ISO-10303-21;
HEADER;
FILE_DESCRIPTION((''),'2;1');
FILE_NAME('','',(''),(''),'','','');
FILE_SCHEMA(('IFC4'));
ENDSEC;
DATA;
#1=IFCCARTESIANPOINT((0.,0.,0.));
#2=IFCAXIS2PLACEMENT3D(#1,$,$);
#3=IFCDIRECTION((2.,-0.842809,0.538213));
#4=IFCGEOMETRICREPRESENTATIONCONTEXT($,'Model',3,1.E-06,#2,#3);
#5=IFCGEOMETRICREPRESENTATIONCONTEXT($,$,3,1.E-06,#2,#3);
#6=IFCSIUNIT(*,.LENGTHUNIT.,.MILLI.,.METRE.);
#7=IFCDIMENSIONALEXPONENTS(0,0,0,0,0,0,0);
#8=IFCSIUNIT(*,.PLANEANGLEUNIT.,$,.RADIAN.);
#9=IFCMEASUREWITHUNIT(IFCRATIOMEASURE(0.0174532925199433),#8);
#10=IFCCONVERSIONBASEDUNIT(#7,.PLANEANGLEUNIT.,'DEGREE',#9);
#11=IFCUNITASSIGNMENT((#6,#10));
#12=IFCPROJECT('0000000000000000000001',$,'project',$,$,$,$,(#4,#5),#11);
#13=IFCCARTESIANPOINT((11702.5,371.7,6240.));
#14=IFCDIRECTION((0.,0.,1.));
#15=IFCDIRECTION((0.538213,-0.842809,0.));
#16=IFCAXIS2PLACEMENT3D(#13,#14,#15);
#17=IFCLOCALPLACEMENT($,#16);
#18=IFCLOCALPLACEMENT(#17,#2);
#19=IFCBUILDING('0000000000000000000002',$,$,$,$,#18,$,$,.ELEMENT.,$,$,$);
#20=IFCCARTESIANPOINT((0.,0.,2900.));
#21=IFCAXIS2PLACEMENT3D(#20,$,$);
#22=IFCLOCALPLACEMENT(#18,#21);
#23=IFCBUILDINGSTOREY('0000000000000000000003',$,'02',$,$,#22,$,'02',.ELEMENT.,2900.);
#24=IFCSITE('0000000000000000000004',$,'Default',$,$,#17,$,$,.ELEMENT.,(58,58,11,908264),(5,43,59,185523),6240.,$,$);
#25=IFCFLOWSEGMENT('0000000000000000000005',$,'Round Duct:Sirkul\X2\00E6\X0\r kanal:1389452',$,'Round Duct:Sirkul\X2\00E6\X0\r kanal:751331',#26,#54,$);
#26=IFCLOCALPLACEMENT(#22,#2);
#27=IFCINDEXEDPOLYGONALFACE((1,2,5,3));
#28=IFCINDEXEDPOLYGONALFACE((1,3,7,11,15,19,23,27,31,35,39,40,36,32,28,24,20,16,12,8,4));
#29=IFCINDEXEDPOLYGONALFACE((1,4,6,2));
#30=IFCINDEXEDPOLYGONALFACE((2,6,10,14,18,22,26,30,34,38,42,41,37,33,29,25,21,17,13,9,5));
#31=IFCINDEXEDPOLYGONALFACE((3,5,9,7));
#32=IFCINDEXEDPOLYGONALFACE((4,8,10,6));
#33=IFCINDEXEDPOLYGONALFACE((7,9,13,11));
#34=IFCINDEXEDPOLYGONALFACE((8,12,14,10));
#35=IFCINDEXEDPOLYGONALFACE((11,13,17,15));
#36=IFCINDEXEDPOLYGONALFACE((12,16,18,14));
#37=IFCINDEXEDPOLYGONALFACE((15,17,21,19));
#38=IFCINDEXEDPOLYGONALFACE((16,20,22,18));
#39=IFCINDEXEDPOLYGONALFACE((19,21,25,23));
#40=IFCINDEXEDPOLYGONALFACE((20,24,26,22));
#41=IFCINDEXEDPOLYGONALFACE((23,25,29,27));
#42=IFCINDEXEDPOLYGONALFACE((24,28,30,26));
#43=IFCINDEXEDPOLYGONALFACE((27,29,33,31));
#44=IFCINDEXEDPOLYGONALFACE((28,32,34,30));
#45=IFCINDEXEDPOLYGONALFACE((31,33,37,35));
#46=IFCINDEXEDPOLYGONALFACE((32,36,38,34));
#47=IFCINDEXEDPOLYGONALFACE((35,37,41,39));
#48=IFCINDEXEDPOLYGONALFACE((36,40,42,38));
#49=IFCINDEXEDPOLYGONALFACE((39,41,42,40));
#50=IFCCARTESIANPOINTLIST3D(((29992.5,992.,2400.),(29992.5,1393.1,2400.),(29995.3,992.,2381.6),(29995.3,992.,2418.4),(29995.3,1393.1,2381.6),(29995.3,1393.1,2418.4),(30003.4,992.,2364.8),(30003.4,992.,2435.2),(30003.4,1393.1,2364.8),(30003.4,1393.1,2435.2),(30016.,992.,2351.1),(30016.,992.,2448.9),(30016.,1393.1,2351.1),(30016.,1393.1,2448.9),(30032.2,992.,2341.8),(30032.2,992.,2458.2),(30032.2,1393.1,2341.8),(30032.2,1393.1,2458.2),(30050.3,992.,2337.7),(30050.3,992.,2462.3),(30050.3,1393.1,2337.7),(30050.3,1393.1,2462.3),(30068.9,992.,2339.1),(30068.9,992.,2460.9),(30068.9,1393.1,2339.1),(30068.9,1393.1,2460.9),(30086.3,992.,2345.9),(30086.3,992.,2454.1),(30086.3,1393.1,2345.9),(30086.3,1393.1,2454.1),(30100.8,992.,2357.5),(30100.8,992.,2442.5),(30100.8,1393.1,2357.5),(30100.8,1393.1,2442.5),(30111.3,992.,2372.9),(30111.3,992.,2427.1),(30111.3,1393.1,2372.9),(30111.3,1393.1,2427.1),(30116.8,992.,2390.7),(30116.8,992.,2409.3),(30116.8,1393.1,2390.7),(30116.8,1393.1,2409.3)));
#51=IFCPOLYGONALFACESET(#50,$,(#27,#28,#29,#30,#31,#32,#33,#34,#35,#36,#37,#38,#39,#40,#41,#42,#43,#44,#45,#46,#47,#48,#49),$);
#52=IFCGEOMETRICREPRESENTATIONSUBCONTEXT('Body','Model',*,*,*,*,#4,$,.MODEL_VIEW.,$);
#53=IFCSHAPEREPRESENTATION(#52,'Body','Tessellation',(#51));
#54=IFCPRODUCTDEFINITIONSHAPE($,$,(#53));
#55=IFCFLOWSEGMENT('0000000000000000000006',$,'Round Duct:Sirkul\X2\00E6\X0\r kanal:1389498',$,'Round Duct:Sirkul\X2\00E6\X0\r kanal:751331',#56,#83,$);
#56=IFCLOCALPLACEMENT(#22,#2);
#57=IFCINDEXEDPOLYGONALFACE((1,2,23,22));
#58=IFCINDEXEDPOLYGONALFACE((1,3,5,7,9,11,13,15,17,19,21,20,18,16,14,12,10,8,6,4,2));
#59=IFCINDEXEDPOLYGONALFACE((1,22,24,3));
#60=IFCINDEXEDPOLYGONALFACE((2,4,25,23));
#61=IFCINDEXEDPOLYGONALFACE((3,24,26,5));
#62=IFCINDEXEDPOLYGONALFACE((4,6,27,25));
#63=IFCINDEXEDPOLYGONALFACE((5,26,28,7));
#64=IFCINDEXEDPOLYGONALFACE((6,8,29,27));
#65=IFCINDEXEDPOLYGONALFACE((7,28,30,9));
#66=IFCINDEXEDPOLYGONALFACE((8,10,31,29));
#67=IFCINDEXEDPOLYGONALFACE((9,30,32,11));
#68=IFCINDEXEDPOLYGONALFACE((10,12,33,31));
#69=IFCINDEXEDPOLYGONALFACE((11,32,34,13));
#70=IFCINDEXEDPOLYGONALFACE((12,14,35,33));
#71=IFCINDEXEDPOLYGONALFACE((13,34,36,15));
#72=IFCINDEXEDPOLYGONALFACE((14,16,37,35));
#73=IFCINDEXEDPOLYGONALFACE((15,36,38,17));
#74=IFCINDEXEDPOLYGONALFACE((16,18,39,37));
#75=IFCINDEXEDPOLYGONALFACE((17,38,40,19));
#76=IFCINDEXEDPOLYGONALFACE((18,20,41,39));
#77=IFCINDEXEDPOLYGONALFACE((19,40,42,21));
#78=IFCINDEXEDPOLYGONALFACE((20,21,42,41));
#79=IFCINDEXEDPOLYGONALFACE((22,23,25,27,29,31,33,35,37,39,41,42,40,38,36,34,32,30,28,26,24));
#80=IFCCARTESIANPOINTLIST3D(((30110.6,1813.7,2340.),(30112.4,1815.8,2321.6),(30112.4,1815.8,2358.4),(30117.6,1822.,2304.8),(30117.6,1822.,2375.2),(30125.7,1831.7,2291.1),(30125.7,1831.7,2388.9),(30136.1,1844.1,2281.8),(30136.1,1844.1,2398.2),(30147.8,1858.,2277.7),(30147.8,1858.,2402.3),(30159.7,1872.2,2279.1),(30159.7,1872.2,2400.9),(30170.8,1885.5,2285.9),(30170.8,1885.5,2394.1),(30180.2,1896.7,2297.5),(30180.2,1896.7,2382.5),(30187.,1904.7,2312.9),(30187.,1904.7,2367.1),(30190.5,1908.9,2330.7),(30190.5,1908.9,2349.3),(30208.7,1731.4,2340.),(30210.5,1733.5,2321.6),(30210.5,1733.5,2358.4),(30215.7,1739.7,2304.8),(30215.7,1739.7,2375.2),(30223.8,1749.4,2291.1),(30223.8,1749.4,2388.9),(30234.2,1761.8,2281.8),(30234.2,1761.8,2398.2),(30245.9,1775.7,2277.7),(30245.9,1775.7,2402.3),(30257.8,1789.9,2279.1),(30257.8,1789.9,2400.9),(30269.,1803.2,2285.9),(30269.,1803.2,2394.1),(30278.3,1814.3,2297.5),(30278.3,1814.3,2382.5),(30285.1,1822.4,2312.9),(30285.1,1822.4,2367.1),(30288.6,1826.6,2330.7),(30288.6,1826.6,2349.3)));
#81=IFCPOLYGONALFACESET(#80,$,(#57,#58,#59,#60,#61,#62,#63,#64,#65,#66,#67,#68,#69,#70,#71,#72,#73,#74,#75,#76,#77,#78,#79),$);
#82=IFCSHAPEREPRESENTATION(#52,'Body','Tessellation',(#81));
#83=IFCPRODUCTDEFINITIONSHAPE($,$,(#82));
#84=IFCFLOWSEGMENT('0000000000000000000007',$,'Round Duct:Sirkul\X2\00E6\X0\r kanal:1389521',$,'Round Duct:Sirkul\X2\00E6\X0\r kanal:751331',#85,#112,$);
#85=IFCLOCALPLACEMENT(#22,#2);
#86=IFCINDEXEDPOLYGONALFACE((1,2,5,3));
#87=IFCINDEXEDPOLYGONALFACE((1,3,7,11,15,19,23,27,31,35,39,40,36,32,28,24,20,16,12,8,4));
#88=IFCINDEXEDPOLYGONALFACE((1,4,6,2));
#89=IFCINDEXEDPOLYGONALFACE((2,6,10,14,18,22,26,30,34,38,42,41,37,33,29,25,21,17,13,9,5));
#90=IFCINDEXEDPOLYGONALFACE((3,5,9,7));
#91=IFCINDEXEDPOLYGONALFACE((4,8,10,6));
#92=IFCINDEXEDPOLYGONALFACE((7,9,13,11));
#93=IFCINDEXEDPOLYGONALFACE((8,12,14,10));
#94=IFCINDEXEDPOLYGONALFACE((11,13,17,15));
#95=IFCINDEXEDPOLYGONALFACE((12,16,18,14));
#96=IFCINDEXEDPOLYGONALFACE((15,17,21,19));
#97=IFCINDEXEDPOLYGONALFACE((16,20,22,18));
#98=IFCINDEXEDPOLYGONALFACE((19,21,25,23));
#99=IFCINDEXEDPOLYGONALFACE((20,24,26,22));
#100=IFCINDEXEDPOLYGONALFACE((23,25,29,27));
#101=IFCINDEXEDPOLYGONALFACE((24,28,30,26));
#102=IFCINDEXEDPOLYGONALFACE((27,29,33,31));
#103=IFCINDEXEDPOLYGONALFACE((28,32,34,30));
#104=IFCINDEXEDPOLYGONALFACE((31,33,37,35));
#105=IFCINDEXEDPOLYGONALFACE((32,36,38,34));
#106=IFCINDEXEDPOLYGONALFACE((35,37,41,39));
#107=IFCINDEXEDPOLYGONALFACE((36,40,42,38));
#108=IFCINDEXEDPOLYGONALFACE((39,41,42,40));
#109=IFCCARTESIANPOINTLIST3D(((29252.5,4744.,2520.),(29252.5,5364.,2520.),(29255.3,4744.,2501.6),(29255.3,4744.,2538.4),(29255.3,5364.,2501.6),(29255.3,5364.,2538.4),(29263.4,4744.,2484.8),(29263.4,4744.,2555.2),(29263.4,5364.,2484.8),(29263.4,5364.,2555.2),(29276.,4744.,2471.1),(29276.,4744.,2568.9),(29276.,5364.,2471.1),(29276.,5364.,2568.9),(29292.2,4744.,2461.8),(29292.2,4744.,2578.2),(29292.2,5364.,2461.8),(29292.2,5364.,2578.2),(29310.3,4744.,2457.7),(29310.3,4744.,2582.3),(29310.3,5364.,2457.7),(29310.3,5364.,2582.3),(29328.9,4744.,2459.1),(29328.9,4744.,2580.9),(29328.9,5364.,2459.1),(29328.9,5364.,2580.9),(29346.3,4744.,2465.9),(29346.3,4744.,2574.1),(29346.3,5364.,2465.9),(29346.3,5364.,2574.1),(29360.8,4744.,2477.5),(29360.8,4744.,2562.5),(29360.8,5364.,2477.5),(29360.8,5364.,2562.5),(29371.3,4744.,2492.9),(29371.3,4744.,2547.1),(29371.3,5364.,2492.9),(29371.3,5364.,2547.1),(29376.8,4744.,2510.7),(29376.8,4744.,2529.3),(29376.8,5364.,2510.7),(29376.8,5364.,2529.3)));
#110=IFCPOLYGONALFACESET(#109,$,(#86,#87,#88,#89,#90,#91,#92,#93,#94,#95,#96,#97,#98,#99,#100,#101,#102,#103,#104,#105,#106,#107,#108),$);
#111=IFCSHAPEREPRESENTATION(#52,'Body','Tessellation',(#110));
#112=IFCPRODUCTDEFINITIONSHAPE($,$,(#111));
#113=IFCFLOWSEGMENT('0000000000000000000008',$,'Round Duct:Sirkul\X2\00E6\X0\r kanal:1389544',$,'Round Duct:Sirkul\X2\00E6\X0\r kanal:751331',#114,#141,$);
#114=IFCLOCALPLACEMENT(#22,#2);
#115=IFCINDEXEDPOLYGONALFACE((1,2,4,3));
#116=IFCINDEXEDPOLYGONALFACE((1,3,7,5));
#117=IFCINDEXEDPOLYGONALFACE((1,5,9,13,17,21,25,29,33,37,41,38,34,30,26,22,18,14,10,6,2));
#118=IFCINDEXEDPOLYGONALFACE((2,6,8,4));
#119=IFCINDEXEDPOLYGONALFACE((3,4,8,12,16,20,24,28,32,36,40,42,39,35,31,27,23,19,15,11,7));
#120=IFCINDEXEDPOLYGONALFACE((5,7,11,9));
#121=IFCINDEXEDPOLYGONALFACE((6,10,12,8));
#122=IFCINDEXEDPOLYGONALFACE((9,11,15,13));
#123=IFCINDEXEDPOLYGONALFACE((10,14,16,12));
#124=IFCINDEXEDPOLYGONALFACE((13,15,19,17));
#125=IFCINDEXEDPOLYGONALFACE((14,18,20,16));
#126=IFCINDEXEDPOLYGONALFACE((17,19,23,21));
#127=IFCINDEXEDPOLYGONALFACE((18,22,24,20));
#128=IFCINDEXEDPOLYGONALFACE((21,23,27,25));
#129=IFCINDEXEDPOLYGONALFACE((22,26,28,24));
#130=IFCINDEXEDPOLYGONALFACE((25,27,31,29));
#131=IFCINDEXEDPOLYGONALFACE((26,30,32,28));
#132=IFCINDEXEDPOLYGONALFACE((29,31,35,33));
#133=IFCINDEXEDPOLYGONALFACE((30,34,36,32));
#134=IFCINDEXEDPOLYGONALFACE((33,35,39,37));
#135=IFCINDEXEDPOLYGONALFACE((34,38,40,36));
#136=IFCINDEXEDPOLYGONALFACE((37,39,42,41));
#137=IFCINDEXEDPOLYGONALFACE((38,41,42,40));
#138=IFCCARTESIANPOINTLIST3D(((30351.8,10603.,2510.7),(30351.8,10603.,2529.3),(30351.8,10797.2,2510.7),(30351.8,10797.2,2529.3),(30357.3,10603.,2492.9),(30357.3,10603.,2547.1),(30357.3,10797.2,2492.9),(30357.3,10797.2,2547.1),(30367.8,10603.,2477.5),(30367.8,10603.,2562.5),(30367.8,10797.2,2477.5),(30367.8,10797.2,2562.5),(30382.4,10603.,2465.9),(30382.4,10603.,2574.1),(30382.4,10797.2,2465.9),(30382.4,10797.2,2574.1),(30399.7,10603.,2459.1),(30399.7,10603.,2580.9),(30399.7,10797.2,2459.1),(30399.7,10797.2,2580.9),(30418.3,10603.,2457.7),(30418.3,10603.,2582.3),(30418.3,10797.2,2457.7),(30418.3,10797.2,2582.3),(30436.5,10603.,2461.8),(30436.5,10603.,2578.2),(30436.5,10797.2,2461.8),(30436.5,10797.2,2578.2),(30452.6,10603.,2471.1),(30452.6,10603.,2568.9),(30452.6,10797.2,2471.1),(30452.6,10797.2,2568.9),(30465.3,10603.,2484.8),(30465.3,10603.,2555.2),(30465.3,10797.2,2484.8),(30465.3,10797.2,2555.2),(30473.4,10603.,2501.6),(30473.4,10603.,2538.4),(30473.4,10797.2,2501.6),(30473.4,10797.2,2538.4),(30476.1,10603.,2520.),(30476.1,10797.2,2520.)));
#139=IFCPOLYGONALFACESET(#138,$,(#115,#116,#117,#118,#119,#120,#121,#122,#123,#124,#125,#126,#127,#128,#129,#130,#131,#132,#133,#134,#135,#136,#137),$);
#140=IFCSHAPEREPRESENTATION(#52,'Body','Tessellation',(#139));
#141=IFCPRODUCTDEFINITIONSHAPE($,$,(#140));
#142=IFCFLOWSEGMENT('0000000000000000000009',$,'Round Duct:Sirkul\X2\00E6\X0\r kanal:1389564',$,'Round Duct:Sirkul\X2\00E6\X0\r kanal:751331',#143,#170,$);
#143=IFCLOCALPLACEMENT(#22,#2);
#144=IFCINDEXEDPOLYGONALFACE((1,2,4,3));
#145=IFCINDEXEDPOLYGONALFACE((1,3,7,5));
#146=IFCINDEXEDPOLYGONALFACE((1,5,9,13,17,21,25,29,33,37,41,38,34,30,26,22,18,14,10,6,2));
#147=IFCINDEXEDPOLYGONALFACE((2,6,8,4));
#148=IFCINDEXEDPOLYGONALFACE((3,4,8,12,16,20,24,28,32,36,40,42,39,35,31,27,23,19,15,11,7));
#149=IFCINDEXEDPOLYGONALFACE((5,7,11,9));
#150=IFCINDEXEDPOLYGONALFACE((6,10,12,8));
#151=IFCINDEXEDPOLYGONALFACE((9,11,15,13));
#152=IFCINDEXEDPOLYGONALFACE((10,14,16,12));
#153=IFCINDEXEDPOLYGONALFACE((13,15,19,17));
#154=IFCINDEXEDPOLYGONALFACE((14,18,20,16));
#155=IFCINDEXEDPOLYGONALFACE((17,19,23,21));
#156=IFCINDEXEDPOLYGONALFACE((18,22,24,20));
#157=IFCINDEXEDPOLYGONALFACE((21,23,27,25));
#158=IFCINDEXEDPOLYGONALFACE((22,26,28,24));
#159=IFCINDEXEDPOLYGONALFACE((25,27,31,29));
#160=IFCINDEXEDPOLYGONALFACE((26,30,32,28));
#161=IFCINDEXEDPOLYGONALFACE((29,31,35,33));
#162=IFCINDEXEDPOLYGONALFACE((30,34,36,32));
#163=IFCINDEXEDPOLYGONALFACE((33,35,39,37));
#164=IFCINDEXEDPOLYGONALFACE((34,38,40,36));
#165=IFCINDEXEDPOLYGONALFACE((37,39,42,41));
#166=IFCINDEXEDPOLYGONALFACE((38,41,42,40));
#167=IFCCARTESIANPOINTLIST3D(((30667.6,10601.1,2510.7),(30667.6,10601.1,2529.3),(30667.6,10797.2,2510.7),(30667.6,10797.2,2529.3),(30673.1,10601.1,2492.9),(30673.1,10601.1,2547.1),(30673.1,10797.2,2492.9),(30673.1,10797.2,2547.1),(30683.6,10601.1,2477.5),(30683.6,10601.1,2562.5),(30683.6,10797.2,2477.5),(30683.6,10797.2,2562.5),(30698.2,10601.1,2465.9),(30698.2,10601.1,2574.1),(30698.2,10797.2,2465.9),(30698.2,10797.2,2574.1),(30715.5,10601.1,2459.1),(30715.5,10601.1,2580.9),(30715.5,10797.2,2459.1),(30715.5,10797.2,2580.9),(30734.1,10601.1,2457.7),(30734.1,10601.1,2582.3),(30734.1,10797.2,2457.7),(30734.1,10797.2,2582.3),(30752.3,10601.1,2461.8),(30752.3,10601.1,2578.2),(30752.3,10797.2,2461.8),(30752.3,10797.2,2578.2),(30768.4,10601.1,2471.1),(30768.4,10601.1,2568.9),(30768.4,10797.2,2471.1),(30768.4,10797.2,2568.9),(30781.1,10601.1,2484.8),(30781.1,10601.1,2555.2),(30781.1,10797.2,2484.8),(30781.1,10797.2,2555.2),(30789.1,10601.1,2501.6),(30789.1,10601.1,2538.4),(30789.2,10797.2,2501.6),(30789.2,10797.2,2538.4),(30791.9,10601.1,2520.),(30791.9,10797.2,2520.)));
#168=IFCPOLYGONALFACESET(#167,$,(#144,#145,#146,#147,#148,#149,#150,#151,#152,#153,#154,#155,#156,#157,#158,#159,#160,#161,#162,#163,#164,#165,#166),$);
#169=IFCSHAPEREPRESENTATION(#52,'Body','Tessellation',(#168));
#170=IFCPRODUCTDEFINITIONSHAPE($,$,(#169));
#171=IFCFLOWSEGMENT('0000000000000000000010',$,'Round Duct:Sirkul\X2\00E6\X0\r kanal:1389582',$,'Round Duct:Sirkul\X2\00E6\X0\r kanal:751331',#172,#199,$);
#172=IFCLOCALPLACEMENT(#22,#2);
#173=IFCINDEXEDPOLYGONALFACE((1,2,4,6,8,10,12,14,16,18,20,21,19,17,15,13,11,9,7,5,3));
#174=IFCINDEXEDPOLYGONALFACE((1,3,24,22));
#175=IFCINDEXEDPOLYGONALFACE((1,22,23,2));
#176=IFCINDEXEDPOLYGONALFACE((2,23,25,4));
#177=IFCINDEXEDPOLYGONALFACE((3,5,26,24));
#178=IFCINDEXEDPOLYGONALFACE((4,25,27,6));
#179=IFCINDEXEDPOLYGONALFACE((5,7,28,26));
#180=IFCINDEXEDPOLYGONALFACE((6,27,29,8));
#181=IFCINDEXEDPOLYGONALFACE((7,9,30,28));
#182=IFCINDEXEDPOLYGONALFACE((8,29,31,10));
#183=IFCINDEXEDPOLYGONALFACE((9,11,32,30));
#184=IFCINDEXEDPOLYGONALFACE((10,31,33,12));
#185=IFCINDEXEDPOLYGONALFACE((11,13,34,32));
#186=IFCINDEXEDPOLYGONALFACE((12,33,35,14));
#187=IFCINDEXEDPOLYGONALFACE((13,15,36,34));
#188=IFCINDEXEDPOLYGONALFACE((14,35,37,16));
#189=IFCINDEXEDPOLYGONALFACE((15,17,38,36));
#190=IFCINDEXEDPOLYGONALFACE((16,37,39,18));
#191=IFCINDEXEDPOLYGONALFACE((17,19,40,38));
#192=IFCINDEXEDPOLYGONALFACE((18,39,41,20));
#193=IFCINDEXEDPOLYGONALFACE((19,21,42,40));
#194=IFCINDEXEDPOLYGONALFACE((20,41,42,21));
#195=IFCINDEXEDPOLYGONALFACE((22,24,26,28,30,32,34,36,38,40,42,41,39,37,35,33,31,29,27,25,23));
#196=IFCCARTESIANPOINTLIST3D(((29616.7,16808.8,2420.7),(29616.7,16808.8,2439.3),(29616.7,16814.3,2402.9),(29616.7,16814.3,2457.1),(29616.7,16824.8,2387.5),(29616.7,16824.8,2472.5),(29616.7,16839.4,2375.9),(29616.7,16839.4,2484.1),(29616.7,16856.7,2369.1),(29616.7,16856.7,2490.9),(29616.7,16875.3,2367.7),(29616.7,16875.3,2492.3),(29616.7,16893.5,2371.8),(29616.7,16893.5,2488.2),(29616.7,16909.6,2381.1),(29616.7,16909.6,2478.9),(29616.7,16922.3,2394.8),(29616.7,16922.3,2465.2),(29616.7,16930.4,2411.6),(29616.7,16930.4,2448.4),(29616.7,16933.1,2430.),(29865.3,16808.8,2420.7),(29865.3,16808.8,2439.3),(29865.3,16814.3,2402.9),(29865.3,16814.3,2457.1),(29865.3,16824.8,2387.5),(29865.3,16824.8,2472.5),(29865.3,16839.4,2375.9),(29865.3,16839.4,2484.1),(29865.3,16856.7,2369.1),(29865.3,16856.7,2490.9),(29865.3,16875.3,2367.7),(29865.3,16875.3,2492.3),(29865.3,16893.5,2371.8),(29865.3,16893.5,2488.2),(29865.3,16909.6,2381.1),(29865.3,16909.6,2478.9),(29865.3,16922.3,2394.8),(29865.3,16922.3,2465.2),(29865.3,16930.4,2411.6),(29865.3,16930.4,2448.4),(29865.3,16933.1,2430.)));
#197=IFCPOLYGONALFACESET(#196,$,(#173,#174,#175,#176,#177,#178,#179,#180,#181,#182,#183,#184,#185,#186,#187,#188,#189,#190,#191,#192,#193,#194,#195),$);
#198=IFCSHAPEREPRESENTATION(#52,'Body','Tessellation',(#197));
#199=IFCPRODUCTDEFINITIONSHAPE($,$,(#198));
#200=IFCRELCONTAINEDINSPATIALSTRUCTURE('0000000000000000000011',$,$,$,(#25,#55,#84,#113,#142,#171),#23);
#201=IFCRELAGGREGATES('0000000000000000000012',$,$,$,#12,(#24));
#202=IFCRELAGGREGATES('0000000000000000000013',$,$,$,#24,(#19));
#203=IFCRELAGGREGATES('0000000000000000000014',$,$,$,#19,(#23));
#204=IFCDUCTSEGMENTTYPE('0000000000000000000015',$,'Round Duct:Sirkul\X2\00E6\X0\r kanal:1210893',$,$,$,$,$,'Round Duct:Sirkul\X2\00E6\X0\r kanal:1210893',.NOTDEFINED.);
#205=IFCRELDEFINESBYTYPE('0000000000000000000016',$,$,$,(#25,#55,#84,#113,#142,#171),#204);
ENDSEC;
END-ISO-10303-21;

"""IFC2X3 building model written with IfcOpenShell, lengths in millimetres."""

from ifc_helpers import new_model, entity, si_unit, converted_unit, direction, frame, frame_2d, origin, origin_2d_with_axis, place, context, subcontext, project, spatial, circle, extrude, type_object, element, save


model = new_model("IFC2X3")

# Units and contexts
model_context = context("Model", 3, precision=1e-06, world=origin(), true_north=direction((2.0, -0.842809, 0.538213)))
context_of_model = context(None, 3, precision=1e-06, world=origin(), true_north=direction((2.0, -0.842809, 0.538213)))
body_context = subcontext(model_context, "Body", "Model", "MODEL_VIEW")
ifc_project = project(units=[si_unit("LENGTHUNIT", "METRE", prefix="MILLI"), converted_unit("PLANEANGLEUNIT", "DEGREE", entity("IfcRatioMeasure", 0.0174532925199433), si_unit("PLANEANGLEUNIT", "RADIAN"), dimensions=[0, 0, 0, 0, 0, 0, 0])], contexts=[model_context, context_of_model])

# Site, building, storey
site_placement = place(None, frame((11702.5, 371.7, 6240.0), z_axis=(0.0, 0.0, 1.0), x_axis=(0.538213, -0.842809, 0.0)))
site = spatial("IfcSite", under=ifc_project, at=site_placement, Name="Default", CompositionType="ELEMENT", RefLatitude=(58, 58, 11, 908264), RefLongitude=(5, 43, 59, 185523), RefElevation=6240.0)
building_placement = place(site_placement, origin())
building = spatial("IfcBuilding", under=site, at=building_placement, CompositionType="ELEMENT")
storey_placement = place(building_placement, frame((0.0, 0.0, 2900.0)))
storey = spatial("IfcBuildingStorey", under=building, at=storey_placement, Name="02", LongName="02", CompositionType="ELEMENT", Elevation=2900.0)

# Flow segments
duct_segment_type = type_object("IfcDuctSegmentType", Name="Round Duct:Sirkulær kanal:1210893", ElementType="Round Duct:Sirkulær kanal:1210893", PredefinedType="NOTDEFINED")
flow_segment_1_placement = place(storey_placement, origin())
element("IfcFlowSegment", 1, at=flow_segment_1_placement, inside=storey, type_object=duct_segment_type, Name="Round Duct:Sirkulær kanal:1389452", ObjectType="Round Duct:Sirkulær kanal:751331", context=body_context, shape_type="SweptSolid", body=[
    extrude(circle(Radius=62.5, at=origin_2d_with_axis()), frame((30055.0, 992.0, 2400.0), z_axis=(0.0, 1.0, 0.0), x_axis=(-1.0, 0.0, 0.0)), (0.0, 0.0, 1.0), 401.0),
])
flow_segment_2_placement = place(storey_placement, origin())
element("IfcFlowSegment", 2, at=flow_segment_2_placement, inside=storey, type_object=duct_segment_type, Name="Round Duct:Sirkulær kanal:1389498", ObjectType="Round Duct:Sirkulær kanal:751331", context=body_context, shape_type="SweptSolid", body=[
    extrude(circle(Radius=62.5, at=frame_2d((0.0, 0.0), x_axis=(1.0, 0.0))), frame((30248.9, 1779.2, 2340.0), z_axis=(-0.766044, 0.642788, 0.0), x_axis=(-0.642788, -0.766044, 0.0)), (0.0, 0.0, 1.0), 128.1),
])
flow_segment_3_placement = place(storey_placement, origin())
element("IfcFlowSegment", 3, at=flow_segment_3_placement, inside=storey, type_object=duct_segment_type, Name="Round Duct:Sirkulær kanal:1389521", ObjectType="Round Duct:Sirkulær kanal:751331", context=body_context, shape_type="SweptSolid", body=[
    extrude(circle(Radius=62.5, at=origin_2d_with_axis()), frame((29315.0, 4744.0, 2520.0), z_axis=(0.0, 1.0, 0.0), x_axis=(-1.0, 0.0, 0.0)), (0.0, 0.0, 1.0), 620.0),
])
flow_segment_4_placement = place(storey_placement, origin())
element("IfcFlowSegment", 4, at=flow_segment_4_placement, inside=storey, type_object=duct_segment_type, Name="Round Duct:Sirkulær kanal:1389544", ObjectType="Round Duct:Sirkulær kanal:751331", context=body_context, shape_type="SweptSolid", body=[
    extrude(circle(Radius=62.5, at=origin_2d_with_axis()), frame((30413.6, 10603.0, 2520.0), z_axis=(0.000053, 1.0, 0.0), x_axis=(1.0, -0.000053, 0.0)), (0.0, 0.0, 1.0), 194.2),
])
flow_segment_5_placement = place(storey_placement, origin())
element("IfcFlowSegment", 5, at=flow_segment_5_placement, inside=storey, type_object=duct_segment_type, Name="Round Duct:Sirkulær kanal:1389564", ObjectType="Round Duct:Sirkulær kanal:751331", context=body_context, shape_type="SweptSolid", body=[
    extrude(circle(Radius=62.5, at=origin_2d_with_axis()), frame((30729.4, 10601.1, 2520.0), z_axis=(0.000053, 1.0, 0.0), x_axis=(1.0, -0.000053, 0.0)), (0.0, 0.0, 1.0), 196.1),
])
flow_segment_6_placement = place(storey_placement, origin())
element("IfcFlowSegment", 6, at=flow_segment_6_placement, inside=storey, type_object=duct_segment_type, Name="Round Duct:Sirkulær kanal:1389582", ObjectType="Round Duct:Sirkulær kanal:751331", context=body_context, shape_type="SweptSolid", body=[
    extrude(circle(Radius=62.5, at=origin_2d_with_axis()), frame((29616.7, 16870.6, 2430.0), z_axis=(1.0, 0.0, 0.0), x_axis=(0.0, 1.0, 0.0)), (0.0, 0.0, 1.0), 248.6),
])

save(model, "model.ifc")
